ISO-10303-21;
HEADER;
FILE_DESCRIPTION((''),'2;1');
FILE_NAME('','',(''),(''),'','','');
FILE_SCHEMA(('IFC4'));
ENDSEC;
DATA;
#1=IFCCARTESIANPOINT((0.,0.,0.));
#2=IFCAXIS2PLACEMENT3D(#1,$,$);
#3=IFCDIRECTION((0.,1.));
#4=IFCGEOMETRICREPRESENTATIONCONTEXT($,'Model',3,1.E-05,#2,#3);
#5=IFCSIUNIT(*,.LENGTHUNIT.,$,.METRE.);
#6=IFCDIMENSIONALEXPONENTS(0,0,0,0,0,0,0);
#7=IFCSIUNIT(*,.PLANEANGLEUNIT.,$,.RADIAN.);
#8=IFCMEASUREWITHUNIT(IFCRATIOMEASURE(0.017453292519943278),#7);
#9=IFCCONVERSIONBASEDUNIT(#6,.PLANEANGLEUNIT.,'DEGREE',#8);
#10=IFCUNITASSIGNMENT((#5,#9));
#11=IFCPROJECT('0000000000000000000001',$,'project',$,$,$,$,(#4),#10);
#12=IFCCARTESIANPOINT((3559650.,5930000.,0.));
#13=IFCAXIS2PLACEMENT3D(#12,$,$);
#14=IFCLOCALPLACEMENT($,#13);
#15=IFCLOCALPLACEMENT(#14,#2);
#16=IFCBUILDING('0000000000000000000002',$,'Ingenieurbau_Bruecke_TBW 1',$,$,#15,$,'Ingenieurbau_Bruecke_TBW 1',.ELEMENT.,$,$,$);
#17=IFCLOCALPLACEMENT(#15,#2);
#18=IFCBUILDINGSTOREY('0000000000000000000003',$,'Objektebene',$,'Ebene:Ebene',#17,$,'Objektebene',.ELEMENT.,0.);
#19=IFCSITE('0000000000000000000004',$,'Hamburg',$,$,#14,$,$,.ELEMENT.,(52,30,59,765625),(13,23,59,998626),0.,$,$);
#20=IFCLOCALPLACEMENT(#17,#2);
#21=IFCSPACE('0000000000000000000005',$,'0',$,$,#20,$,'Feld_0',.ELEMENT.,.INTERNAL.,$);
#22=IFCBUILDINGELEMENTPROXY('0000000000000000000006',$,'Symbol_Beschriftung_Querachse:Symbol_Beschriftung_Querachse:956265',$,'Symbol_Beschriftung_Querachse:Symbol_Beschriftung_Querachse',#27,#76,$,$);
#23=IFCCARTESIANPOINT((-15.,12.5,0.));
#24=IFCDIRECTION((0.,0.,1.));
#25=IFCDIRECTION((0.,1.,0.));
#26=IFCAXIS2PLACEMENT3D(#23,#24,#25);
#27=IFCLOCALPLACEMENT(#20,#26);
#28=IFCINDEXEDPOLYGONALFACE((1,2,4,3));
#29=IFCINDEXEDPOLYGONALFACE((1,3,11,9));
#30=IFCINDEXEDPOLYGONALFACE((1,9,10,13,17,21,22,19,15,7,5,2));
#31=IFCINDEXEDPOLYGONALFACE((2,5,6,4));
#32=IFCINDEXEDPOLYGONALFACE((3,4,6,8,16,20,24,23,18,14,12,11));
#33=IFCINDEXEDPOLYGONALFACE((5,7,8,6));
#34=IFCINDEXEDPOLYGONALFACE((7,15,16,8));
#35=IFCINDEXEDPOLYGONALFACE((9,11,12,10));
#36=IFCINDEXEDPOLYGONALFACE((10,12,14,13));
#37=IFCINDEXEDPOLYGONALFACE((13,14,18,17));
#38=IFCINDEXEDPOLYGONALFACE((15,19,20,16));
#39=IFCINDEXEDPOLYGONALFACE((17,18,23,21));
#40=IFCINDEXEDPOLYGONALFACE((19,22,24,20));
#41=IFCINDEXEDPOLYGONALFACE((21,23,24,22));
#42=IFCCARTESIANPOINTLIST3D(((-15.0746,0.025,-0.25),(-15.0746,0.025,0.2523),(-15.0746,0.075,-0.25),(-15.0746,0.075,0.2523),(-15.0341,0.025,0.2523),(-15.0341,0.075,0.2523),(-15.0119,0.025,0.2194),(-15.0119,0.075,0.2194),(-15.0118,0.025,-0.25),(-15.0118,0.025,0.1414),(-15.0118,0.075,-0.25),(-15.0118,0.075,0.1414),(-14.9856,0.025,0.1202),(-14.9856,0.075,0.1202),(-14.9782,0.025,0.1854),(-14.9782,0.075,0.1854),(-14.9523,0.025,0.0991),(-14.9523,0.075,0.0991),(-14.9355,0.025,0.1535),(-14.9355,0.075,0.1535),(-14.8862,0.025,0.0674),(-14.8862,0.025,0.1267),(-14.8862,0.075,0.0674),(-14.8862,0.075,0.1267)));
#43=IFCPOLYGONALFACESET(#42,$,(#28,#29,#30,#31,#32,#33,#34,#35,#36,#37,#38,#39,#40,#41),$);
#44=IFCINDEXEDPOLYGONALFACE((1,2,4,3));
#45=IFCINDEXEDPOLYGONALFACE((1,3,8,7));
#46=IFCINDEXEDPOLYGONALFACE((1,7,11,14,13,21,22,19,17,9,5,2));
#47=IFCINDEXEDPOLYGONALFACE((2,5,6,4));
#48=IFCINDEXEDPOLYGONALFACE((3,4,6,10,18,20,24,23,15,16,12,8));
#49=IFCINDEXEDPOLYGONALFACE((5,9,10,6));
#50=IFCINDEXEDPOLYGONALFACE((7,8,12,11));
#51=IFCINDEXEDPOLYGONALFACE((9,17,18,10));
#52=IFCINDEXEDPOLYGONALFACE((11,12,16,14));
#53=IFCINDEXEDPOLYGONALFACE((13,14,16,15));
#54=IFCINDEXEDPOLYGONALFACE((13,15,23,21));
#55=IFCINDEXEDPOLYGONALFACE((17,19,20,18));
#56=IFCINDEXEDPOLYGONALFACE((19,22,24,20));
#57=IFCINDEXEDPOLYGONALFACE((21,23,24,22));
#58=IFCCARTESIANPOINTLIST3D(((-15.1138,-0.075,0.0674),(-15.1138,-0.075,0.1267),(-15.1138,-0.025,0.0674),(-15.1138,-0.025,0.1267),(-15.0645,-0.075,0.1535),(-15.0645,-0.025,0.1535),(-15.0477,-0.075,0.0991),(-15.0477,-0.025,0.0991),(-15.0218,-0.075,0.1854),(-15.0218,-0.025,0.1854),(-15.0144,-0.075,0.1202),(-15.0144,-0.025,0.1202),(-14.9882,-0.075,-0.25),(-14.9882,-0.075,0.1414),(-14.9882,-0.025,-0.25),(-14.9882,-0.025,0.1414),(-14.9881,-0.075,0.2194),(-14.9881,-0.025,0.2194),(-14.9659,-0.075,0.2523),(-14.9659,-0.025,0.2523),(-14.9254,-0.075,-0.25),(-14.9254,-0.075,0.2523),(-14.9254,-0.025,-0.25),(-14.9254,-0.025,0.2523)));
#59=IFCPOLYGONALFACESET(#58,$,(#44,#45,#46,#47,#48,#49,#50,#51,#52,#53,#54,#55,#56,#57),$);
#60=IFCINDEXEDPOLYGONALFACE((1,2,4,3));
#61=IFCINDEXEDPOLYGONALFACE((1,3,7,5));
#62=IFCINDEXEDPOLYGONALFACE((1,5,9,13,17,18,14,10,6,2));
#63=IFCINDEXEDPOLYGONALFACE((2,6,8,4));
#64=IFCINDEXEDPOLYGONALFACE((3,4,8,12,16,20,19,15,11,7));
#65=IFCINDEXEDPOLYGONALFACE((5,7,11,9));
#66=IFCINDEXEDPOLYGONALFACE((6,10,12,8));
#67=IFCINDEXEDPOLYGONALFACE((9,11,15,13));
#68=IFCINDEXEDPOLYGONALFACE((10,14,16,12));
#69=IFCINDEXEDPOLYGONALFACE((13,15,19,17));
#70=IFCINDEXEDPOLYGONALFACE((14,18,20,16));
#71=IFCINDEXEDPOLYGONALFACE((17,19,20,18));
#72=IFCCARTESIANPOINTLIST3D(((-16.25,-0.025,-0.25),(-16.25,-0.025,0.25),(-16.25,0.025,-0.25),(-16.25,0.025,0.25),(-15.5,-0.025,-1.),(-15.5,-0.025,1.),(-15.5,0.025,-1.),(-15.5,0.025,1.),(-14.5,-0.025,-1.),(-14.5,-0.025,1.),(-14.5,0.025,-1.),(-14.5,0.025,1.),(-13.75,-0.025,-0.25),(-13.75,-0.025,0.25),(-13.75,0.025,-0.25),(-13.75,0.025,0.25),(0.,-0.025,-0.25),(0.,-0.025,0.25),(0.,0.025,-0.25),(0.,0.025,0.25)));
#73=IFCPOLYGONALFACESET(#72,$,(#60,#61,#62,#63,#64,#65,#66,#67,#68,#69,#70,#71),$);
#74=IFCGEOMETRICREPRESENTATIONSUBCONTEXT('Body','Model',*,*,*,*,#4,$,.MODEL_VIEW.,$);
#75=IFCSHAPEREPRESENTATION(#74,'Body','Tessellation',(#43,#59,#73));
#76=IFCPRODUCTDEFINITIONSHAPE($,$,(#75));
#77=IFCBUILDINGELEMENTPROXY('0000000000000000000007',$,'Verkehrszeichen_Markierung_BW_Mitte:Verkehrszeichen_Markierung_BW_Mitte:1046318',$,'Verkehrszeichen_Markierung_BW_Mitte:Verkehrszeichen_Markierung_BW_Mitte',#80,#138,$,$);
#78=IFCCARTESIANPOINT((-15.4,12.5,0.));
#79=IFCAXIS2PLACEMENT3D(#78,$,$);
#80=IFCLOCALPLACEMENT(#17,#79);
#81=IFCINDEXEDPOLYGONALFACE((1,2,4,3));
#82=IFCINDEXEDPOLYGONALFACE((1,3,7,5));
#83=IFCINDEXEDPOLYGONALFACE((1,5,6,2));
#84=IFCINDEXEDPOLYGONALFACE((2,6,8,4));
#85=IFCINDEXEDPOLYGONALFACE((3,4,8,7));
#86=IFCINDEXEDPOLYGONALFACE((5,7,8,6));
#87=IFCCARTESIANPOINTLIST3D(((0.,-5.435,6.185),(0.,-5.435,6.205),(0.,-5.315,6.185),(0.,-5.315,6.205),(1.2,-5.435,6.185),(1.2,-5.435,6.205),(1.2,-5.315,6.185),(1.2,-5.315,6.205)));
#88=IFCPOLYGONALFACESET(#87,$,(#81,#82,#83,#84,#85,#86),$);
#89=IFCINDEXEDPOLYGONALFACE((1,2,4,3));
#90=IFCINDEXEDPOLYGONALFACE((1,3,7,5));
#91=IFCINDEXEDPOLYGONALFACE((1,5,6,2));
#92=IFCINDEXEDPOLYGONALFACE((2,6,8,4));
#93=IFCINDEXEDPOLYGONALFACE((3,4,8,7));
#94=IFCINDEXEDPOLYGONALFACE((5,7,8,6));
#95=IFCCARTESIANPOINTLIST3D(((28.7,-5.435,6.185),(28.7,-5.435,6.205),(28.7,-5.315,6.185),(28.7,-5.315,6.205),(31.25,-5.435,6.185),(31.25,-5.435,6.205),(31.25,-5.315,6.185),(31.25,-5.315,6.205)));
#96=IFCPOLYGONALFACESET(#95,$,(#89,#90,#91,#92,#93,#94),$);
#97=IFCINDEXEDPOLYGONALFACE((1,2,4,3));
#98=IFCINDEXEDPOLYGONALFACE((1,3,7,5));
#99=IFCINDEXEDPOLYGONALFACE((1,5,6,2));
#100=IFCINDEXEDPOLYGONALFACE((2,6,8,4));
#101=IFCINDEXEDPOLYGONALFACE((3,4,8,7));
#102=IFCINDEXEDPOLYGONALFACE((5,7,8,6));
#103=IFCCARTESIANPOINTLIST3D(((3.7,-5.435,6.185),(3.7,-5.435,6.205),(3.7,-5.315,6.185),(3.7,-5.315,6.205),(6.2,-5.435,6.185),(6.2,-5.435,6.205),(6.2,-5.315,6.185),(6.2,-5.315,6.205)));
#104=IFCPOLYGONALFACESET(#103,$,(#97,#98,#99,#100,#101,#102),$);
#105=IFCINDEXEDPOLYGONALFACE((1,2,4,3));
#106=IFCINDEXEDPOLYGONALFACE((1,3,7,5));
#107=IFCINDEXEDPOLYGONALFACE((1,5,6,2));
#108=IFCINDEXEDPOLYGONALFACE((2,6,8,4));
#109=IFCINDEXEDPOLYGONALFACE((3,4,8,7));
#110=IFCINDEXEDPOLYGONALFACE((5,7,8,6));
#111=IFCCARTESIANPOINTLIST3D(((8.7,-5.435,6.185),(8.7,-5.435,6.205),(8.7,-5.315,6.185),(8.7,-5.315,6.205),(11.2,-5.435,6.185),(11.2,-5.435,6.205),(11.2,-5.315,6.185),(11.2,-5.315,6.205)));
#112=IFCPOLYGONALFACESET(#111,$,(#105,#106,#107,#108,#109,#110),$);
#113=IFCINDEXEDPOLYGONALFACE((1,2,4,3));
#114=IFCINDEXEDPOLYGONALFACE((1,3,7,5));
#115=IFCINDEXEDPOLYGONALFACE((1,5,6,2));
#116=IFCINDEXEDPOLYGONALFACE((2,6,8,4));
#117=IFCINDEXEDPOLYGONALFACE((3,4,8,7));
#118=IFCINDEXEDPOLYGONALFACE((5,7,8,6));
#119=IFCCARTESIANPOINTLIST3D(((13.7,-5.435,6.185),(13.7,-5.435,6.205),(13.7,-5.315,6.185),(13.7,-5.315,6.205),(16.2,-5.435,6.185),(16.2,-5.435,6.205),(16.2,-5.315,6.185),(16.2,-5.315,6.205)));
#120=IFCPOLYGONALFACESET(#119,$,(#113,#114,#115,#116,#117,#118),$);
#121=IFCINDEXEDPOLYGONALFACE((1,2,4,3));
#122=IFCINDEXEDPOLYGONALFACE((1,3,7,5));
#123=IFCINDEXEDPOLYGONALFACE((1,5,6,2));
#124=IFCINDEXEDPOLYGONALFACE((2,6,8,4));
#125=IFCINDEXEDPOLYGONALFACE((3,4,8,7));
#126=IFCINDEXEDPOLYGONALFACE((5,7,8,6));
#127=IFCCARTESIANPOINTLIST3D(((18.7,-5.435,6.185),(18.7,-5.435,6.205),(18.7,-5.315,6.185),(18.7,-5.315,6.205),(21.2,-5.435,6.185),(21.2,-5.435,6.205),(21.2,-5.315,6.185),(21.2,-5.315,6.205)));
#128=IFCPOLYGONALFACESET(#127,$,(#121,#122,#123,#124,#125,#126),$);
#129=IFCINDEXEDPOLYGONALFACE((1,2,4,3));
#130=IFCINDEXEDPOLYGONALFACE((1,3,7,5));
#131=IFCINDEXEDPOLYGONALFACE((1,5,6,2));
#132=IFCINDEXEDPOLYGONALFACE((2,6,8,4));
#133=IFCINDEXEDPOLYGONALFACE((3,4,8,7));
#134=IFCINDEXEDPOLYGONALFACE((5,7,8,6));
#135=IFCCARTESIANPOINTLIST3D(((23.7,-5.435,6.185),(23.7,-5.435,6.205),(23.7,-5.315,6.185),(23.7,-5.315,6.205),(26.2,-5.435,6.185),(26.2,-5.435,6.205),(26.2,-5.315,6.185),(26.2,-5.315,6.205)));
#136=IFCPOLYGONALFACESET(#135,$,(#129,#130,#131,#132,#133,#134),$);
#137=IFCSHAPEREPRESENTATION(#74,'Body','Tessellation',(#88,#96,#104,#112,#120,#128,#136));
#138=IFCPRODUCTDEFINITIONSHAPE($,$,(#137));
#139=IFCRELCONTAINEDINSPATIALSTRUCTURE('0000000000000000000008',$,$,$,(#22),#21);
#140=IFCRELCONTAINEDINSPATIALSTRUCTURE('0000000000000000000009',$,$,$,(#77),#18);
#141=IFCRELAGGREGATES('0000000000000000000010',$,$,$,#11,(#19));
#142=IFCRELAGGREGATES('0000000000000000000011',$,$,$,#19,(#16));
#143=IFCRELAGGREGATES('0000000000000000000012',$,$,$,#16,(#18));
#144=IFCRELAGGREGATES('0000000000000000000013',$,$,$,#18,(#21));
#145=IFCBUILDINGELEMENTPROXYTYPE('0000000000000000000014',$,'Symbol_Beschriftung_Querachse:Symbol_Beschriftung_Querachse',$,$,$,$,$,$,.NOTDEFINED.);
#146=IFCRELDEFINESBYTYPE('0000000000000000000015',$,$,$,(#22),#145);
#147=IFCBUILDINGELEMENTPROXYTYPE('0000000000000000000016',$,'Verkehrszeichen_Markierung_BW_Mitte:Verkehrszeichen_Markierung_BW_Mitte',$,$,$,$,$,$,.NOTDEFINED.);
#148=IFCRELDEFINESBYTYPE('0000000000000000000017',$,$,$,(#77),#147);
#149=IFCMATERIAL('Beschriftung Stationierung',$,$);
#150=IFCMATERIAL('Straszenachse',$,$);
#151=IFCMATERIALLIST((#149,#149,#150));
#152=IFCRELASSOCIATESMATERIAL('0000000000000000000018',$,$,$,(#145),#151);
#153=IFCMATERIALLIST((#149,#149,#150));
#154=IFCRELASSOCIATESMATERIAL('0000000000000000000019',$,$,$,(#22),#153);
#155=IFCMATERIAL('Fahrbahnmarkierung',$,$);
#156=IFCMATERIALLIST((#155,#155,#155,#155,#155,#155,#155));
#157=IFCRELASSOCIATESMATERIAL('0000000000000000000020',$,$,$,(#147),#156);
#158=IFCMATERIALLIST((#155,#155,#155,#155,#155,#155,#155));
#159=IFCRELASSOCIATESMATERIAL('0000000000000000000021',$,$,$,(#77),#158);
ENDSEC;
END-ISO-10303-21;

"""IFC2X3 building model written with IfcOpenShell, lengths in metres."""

from ifc_helpers import new_model, entity, si_unit, converted_unit, direction, frame, frame_2d, origin, place, context, subcontext, project, spatial, polyline, rectangle, outline, extrude, source, transform, mapped, material, material_list, type_object, type_shapes, element, save


model = new_model("IFC2X3")

# Units and contexts
model_context = context("Model", 3, precision=1e-05, world=origin(), true_north=direction((0.0, 1.0)))
body_context = subcontext(model_context, "Body", "Model", "MODEL_VIEW")
ifc_project = project(units=[si_unit("LENGTHUNIT", "METRE"), converted_unit("PLANEANGLEUNIT", "DEGREE", entity("IfcRatioMeasure", 0.017453292519943278), si_unit("PLANEANGLEUNIT", "RADIAN"), dimensions=[0, 0, 0, 0, 0, 0, 0])], contexts=[model_context])

# Site, building, storey
site_placement = place(None, frame((3559650.0, 5930000.0, 0.0)))
site = spatial("IfcSite", under=ifc_project, at=site_placement, Name="Hamburg", CompositionType="ELEMENT", RefLatitude=(52, 30, 59, 765625), RefLongitude=(13, 23, 59, 998626), RefElevation=0.0)
building_placement = place(site_placement, origin())
building = spatial("IfcBuilding", under=site, at=building_placement, Name="Ingenieurbau_Bruecke_TBW 1", LongName="Ingenieurbau_Bruecke_TBW 1", CompositionType="ELEMENT")
storey_placement = place(building_placement, origin())
storey = spatial("IfcBuildingStorey", under=building, at=storey_placement, Name="Objektebene", ObjectType="Ebene:Ebene", LongName="Objektebene", CompositionType="ELEMENT", Elevation=0.0)

# Shared definitions
space_placement = place(storey_placement, origin())
space = spatial("IfcSpace", under=storey, at=space_placement, Name="0", LongName="Feld_0", CompositionType="ELEMENT", InteriorOrExteriorSpace="INTERNAL")

# Building element proxies
ifc_material_1 = material(Name="Beschriftung Stationierung")
ifc_material_2 = material(Name="Straszenachse")
ifc_material_list_1 = material_list([ifc_material_1, ifc_material_1, ifc_material_2])
ifc_material_list_2 = material_list([ifc_material_1, ifc_material_1, ifc_material_2])
building_element_proxy_type_1 = type_object("IfcBuildingElementProxyType", Name="Symbol_Beschriftung_Querachse:Symbol_Beschriftung_Querachse", PredefinedType="NOTDEFINED", material=ifc_material_list_2)
shared_shape_1 = source(origin(), body_context, "Body", "SweptSolid", [
    extrude(outline(polyline([(-0.3431, -0.0877), (0.1591, -0.0877), (0.1591, -0.0472), (0.1262, -0.025), (0.0923, 0.0087), (0.0604, 0.0514), (0.0336, 0.1007), (-0.0258, 0.1007), (0.0059, 0.0346), (0.0271, 0.0013), (0.0483, -0.0249), (-0.3431, -0.0249), (-0.3431, -0.0877)])), frame((-14.9869, 0.025, 0.0931), z_axis=(0.0, 1.0, 0.0), x_axis=(0.0, 0.0, 1.0)), (0.0, 0.0, 1.0), 0.05),
    extrude(outline(polyline([(-0.0877, -0.3431), (-0.0249, -0.3431), (-0.0249, 0.0483), (0.0013, 0.0271), (0.0346, 0.0059), (0.1007, -0.0258), (0.1007, 0.0336), (0.0514, 0.0604), (0.0087, 0.0923), (-0.025, 0.1262), (-0.0472, 0.1591), (-0.0877, 0.1591), (-0.0877, -0.3431)])), frame((-15.0131, -0.075, 0.0931), z_axis=(0.0, 1.0, 0.0), x_axis=(-1.0, 0.0, 0.0)), (0.0, 0.0, 1.0), 0.05),
    extrude(outline(polyline([(-12.0, 0.25), (-12.0, -0.25), (1.75, -0.25), (2.5, -1.0), (3.5, -1.0), (4.25, -0.25), (4.25, 0.25), (3.5, 1.0), (2.5, 1.0), (1.75, 0.25), (-12.0, 0.25)])), frame((-12.0, -0.025, 0.0), z_axis=(0.0, -1.0, 0.0), x_axis=(-1.0, 0.0, 0.0)), (0.0, 0.0, -1.0), 0.05),
])
type_shapes(building_element_proxy_type_1, [shared_shape_1])
proxy_1_placement = place(space_placement, frame((-15.0, 12.5, 0.0), z_axis=(0.0, 0.0, 1.0), x_axis=(0.0, 1.0, 0.0)))
element("IfcBuildingElementProxy", 1, at=proxy_1_placement, inside=space, type_object=building_element_proxy_type_1, material=ifc_material_list_1, Name="Symbol_Beschriftung_Querachse:Symbol_Beschriftung_Querachse:956265", ObjectType="Symbol_Beschriftung_Querachse:Symbol_Beschriftung_Querachse", context=body_context, shape_type="MappedRepresentation", body=[
    mapped(shared_shape_1, transform((0.0, 0.0, 0.0), scale=1.0)),
])
ifc_material_3 = material(Name="Fahrbahnmarkierung")
ifc_material_list_3 = material_list([ifc_material_3, ifc_material_3, ifc_material_3, ifc_material_3, ifc_material_3, ifc_material_3, ifc_material_3])
ifc_material_list_4 = material_list([ifc_material_3, ifc_material_3, ifc_material_3, ifc_material_3, ifc_material_3, ifc_material_3, ifc_material_3])
building_element_proxy_type_2 = type_object("IfcBuildingElementProxyType", Name="Verkehrszeichen_Markierung_BW_Mitte:Verkehrszeichen_Markierung_BW_Mitte", PredefinedType="NOTDEFINED", material=ifc_material_list_4)
shared_shape_2 = source(origin(), body_context, "Body", "SweptSolid", [
    extrude(rectangle(XDim=1.2, YDim=0.12, at=frame_2d((0.0, 0.0), x_axis=(1.0, 0.0))), frame((0.6, -5.375, 6.185)), (0.0, 0.0, 1.0), 0.02),
    extrude(rectangle(XDim=0.12, YDim=2.55, at=frame_2d((0.0, 0.0), x_axis=(1.0, 0.0))), frame((29.975, -5.375, 6.185), z_axis=(0.0, 0.0, 1.0), x_axis=(0.0, 1.0, 0.0)), (0.0, 0.0, 1.0), 0.02),
    extrude(rectangle(XDim=0.12, YDim=2.5, at=frame_2d((0.0, 0.0), x_axis=(1.0, 0.0))), frame((4.95, -5.375, 6.185), z_axis=(0.0, 0.0, 1.0), x_axis=(0.0, 1.0, 0.0)), (0.0, 0.0, 1.0), 0.02),
    extrude(rectangle(XDim=0.12, YDim=2.5, at=frame_2d((0.0, 0.0), x_axis=(1.0, 0.0))), frame((9.95, -5.375, 6.185), z_axis=(0.0, 0.0, 1.0), x_axis=(0.0, 1.0, 0.0)), (0.0, 0.0, 1.0), 0.02),
    extrude(rectangle(XDim=0.12, YDim=2.5, at=frame_2d((0.0, 0.0), x_axis=(1.0, 0.0))), frame((14.95, -5.375, 6.185), z_axis=(0.0, 0.0, 1.0), x_axis=(0.0, 1.0, 0.0)), (0.0, 0.0, 1.0), 0.02),
    extrude(rectangle(XDim=0.12, YDim=2.5, at=frame_2d((0.0, 0.0), x_axis=(1.0, 0.0))), frame((19.95, -5.375, 6.185), z_axis=(0.0, 0.0, 1.0), x_axis=(0.0, 1.0, 0.0)), (0.0, 0.0, 1.0), 0.02),
    extrude(rectangle(XDim=0.12, YDim=2.5, at=frame_2d((0.0, 0.0), x_axis=(1.0, 0.0))), frame((24.95, -5.375, 6.185), z_axis=(0.0, 0.0, 1.0), x_axis=(0.0, 1.0, 0.0)), (0.0, 0.0, 1.0), 0.02),
])
type_shapes(building_element_proxy_type_2, [shared_shape_2])
proxy_2_placement = place(storey_placement, frame((-15.4, 12.5, 0.0)))
element("IfcBuildingElementProxy", 2, at=proxy_2_placement, inside=storey, type_object=building_element_proxy_type_2, material=ifc_material_list_3, Name="Verkehrszeichen_Markierung_BW_Mitte:Verkehrszeichen_Markierung_BW_Mitte:1046318", ObjectType="Verkehrszeichen_Markierung_BW_Mitte:Verkehrszeichen_Markierung_BW_Mitte", context=body_context, shape_type="MappedRepresentation", body=[
    mapped(shared_shape_2, transform((0.0, 0.0, 0.0), scale=1.0)),
])

save(model, "model.ifc")
